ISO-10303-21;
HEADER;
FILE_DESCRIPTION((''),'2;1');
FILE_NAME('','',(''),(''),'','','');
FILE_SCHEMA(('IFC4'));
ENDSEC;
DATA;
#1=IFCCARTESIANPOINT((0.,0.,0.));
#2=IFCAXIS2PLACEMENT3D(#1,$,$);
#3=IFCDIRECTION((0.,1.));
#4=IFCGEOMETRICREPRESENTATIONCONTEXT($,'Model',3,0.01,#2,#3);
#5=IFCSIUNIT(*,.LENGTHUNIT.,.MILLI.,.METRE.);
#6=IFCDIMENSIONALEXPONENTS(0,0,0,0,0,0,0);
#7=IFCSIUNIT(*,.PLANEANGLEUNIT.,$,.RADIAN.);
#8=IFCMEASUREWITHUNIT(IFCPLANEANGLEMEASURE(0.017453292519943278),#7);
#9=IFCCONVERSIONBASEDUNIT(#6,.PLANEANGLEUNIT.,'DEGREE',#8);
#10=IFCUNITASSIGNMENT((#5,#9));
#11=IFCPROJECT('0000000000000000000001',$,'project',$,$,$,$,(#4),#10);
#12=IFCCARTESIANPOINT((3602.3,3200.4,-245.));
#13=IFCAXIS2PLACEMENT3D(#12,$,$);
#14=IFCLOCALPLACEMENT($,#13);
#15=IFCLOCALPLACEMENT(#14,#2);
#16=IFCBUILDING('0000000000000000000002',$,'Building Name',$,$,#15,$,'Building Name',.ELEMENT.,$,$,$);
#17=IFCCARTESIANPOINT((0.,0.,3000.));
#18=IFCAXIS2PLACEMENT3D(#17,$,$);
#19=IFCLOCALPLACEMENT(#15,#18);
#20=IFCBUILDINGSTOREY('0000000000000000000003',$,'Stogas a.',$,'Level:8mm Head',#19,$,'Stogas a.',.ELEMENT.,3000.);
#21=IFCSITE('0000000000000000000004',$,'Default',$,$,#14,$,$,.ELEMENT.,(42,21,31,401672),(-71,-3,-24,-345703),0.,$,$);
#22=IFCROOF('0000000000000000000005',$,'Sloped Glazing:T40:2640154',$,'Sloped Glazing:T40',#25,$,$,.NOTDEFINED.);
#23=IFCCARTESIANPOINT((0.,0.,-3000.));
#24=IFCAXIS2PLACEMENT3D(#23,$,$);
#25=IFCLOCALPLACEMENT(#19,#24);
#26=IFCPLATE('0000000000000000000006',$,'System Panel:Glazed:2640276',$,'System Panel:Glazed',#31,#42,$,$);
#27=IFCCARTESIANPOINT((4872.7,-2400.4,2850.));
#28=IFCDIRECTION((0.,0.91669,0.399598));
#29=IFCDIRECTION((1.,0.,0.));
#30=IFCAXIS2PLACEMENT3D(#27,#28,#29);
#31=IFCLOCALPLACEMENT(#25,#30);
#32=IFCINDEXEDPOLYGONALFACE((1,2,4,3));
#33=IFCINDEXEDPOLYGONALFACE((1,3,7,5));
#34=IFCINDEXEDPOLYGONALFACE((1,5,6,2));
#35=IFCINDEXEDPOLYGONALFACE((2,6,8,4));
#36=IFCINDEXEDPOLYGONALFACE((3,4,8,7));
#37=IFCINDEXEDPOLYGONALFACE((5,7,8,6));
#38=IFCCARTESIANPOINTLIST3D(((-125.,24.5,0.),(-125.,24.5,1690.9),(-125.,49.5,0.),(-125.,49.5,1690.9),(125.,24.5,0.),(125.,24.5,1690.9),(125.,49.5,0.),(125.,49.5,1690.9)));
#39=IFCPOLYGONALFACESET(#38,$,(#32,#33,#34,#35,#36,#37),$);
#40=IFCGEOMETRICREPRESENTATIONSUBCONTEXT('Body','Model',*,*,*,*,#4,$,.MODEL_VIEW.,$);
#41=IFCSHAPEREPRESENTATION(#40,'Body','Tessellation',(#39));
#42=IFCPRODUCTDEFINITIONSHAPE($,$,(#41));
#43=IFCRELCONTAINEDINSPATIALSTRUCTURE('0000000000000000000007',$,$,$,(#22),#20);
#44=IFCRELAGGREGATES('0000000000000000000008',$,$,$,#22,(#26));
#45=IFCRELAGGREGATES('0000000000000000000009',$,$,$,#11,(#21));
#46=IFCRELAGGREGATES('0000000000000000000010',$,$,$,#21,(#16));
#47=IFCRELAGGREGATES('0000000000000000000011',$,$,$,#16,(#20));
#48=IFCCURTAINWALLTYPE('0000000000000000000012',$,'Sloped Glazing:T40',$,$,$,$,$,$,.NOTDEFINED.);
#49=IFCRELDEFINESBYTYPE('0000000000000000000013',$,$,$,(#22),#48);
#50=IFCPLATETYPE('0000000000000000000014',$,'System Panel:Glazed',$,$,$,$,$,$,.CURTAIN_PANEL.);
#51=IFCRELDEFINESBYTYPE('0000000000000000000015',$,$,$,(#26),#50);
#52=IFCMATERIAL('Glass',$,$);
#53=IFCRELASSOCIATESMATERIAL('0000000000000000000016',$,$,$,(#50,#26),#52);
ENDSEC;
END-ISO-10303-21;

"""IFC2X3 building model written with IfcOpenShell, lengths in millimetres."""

from ifc_helpers import new_model, entity, si_unit, converted_unit, direction, frame, origin, origin_2d_with_axis, place, context, subcontext, project, spatial, rectangle, extrude, source, transform, mapped, material, type_object, type_shapes, element, aggregate, save


model = new_model("IFC2X3")

# Units and contexts
model_context = context("Model", 3, precision=0.01, world=origin(), true_north=direction((0.0, 1.0)))
body_context = subcontext(model_context, "Body", "Model", "MODEL_VIEW")
ifc_project = project(units=[si_unit("LENGTHUNIT", "METRE", prefix="MILLI"), converted_unit("PLANEANGLEUNIT", "DEGREE", entity("IfcPlaneAngleMeasure", 0.017453292519943278), si_unit("PLANEANGLEUNIT", "RADIAN"), dimensions=[0, 0, 0, 0, 0, 0, 0])], contexts=[model_context])

# Site, building, storey
site_placement = place(None, frame((3602.3, 3200.4, -245.0)))
site = spatial("IfcSite", under=ifc_project, at=site_placement, Name="Default", CompositionType="ELEMENT", RefLatitude=(42, 21, 31, 401672), RefLongitude=(-71, -3, -24, -345703), RefElevation=0.0)
building_placement = place(site_placement, origin())
building = spatial("IfcBuilding", under=site, at=building_placement, Name="Building Name", LongName="Building Name", CompositionType="ELEMENT")
storey_placement = place(building_placement, frame((0.0, 0.0, 3000.0)))
storey = spatial("IfcBuildingStorey", under=building, at=storey_placement, Name="Stogas a.", ObjectType="Level:8mm Head", LongName="Stogas a.", CompositionType="ELEMENT", Elevation=3000.0)

# Roof, plate
curtain_wall_type = type_object("IfcCurtainWallType", Name="Sloped Glazing:T40", PredefinedType="NOTDEFINED")
roof_placement = place(storey_placement, frame((0.0, 0.0, -3000.0)))
roof = element("IfcRoof", 1, at=roof_placement, inside=storey, type_object=curtain_wall_type, Name="Sloped Glazing:T40:2640154", ObjectType="Sloped Glazing:T40", ShapeType="NOTDEFINED")
ifc_material_1 = material(Name="Glass")
plate_type = type_object("IfcPlateType", Name="System Panel:Glazed", PredefinedType="CURTAIN_PANEL", material=ifc_material_1)
shared_shape_1 = source(origin(), body_context, "Body", "SweptSolid", [
    extrude(rectangle(XDim=25.0, YDim=250.0, at=origin_2d_with_axis()), frame((0.0, 37.0, 0.0), z_axis=(0.0, 0.0, 1.0), x_axis=(0.0, 1.0, 0.0)), (0.0, 0.0, 1.0), 1690.9),
])
type_shapes(plate_type, [shared_shape_1])
plate_placement = place(roof_placement, frame((4872.7, -2400.4, 2850.0), z_axis=(0.0, 0.91669, 0.399598), x_axis=(1.0, 0.0, 0.0)))
plate = element("IfcPlate", 2, at=plate_placement, type_object=plate_type, material=ifc_material_1, Name="System Panel:Glazed:2640276", ObjectType="System Panel:Glazed", context=body_context, shape_type="MappedRepresentation", body=[
    mapped(shared_shape_1, transform((0.0, 0.0, 0.0), scale=1.0)),
])
aggregate(roof, [plate])

save(model, "model.ifc")
